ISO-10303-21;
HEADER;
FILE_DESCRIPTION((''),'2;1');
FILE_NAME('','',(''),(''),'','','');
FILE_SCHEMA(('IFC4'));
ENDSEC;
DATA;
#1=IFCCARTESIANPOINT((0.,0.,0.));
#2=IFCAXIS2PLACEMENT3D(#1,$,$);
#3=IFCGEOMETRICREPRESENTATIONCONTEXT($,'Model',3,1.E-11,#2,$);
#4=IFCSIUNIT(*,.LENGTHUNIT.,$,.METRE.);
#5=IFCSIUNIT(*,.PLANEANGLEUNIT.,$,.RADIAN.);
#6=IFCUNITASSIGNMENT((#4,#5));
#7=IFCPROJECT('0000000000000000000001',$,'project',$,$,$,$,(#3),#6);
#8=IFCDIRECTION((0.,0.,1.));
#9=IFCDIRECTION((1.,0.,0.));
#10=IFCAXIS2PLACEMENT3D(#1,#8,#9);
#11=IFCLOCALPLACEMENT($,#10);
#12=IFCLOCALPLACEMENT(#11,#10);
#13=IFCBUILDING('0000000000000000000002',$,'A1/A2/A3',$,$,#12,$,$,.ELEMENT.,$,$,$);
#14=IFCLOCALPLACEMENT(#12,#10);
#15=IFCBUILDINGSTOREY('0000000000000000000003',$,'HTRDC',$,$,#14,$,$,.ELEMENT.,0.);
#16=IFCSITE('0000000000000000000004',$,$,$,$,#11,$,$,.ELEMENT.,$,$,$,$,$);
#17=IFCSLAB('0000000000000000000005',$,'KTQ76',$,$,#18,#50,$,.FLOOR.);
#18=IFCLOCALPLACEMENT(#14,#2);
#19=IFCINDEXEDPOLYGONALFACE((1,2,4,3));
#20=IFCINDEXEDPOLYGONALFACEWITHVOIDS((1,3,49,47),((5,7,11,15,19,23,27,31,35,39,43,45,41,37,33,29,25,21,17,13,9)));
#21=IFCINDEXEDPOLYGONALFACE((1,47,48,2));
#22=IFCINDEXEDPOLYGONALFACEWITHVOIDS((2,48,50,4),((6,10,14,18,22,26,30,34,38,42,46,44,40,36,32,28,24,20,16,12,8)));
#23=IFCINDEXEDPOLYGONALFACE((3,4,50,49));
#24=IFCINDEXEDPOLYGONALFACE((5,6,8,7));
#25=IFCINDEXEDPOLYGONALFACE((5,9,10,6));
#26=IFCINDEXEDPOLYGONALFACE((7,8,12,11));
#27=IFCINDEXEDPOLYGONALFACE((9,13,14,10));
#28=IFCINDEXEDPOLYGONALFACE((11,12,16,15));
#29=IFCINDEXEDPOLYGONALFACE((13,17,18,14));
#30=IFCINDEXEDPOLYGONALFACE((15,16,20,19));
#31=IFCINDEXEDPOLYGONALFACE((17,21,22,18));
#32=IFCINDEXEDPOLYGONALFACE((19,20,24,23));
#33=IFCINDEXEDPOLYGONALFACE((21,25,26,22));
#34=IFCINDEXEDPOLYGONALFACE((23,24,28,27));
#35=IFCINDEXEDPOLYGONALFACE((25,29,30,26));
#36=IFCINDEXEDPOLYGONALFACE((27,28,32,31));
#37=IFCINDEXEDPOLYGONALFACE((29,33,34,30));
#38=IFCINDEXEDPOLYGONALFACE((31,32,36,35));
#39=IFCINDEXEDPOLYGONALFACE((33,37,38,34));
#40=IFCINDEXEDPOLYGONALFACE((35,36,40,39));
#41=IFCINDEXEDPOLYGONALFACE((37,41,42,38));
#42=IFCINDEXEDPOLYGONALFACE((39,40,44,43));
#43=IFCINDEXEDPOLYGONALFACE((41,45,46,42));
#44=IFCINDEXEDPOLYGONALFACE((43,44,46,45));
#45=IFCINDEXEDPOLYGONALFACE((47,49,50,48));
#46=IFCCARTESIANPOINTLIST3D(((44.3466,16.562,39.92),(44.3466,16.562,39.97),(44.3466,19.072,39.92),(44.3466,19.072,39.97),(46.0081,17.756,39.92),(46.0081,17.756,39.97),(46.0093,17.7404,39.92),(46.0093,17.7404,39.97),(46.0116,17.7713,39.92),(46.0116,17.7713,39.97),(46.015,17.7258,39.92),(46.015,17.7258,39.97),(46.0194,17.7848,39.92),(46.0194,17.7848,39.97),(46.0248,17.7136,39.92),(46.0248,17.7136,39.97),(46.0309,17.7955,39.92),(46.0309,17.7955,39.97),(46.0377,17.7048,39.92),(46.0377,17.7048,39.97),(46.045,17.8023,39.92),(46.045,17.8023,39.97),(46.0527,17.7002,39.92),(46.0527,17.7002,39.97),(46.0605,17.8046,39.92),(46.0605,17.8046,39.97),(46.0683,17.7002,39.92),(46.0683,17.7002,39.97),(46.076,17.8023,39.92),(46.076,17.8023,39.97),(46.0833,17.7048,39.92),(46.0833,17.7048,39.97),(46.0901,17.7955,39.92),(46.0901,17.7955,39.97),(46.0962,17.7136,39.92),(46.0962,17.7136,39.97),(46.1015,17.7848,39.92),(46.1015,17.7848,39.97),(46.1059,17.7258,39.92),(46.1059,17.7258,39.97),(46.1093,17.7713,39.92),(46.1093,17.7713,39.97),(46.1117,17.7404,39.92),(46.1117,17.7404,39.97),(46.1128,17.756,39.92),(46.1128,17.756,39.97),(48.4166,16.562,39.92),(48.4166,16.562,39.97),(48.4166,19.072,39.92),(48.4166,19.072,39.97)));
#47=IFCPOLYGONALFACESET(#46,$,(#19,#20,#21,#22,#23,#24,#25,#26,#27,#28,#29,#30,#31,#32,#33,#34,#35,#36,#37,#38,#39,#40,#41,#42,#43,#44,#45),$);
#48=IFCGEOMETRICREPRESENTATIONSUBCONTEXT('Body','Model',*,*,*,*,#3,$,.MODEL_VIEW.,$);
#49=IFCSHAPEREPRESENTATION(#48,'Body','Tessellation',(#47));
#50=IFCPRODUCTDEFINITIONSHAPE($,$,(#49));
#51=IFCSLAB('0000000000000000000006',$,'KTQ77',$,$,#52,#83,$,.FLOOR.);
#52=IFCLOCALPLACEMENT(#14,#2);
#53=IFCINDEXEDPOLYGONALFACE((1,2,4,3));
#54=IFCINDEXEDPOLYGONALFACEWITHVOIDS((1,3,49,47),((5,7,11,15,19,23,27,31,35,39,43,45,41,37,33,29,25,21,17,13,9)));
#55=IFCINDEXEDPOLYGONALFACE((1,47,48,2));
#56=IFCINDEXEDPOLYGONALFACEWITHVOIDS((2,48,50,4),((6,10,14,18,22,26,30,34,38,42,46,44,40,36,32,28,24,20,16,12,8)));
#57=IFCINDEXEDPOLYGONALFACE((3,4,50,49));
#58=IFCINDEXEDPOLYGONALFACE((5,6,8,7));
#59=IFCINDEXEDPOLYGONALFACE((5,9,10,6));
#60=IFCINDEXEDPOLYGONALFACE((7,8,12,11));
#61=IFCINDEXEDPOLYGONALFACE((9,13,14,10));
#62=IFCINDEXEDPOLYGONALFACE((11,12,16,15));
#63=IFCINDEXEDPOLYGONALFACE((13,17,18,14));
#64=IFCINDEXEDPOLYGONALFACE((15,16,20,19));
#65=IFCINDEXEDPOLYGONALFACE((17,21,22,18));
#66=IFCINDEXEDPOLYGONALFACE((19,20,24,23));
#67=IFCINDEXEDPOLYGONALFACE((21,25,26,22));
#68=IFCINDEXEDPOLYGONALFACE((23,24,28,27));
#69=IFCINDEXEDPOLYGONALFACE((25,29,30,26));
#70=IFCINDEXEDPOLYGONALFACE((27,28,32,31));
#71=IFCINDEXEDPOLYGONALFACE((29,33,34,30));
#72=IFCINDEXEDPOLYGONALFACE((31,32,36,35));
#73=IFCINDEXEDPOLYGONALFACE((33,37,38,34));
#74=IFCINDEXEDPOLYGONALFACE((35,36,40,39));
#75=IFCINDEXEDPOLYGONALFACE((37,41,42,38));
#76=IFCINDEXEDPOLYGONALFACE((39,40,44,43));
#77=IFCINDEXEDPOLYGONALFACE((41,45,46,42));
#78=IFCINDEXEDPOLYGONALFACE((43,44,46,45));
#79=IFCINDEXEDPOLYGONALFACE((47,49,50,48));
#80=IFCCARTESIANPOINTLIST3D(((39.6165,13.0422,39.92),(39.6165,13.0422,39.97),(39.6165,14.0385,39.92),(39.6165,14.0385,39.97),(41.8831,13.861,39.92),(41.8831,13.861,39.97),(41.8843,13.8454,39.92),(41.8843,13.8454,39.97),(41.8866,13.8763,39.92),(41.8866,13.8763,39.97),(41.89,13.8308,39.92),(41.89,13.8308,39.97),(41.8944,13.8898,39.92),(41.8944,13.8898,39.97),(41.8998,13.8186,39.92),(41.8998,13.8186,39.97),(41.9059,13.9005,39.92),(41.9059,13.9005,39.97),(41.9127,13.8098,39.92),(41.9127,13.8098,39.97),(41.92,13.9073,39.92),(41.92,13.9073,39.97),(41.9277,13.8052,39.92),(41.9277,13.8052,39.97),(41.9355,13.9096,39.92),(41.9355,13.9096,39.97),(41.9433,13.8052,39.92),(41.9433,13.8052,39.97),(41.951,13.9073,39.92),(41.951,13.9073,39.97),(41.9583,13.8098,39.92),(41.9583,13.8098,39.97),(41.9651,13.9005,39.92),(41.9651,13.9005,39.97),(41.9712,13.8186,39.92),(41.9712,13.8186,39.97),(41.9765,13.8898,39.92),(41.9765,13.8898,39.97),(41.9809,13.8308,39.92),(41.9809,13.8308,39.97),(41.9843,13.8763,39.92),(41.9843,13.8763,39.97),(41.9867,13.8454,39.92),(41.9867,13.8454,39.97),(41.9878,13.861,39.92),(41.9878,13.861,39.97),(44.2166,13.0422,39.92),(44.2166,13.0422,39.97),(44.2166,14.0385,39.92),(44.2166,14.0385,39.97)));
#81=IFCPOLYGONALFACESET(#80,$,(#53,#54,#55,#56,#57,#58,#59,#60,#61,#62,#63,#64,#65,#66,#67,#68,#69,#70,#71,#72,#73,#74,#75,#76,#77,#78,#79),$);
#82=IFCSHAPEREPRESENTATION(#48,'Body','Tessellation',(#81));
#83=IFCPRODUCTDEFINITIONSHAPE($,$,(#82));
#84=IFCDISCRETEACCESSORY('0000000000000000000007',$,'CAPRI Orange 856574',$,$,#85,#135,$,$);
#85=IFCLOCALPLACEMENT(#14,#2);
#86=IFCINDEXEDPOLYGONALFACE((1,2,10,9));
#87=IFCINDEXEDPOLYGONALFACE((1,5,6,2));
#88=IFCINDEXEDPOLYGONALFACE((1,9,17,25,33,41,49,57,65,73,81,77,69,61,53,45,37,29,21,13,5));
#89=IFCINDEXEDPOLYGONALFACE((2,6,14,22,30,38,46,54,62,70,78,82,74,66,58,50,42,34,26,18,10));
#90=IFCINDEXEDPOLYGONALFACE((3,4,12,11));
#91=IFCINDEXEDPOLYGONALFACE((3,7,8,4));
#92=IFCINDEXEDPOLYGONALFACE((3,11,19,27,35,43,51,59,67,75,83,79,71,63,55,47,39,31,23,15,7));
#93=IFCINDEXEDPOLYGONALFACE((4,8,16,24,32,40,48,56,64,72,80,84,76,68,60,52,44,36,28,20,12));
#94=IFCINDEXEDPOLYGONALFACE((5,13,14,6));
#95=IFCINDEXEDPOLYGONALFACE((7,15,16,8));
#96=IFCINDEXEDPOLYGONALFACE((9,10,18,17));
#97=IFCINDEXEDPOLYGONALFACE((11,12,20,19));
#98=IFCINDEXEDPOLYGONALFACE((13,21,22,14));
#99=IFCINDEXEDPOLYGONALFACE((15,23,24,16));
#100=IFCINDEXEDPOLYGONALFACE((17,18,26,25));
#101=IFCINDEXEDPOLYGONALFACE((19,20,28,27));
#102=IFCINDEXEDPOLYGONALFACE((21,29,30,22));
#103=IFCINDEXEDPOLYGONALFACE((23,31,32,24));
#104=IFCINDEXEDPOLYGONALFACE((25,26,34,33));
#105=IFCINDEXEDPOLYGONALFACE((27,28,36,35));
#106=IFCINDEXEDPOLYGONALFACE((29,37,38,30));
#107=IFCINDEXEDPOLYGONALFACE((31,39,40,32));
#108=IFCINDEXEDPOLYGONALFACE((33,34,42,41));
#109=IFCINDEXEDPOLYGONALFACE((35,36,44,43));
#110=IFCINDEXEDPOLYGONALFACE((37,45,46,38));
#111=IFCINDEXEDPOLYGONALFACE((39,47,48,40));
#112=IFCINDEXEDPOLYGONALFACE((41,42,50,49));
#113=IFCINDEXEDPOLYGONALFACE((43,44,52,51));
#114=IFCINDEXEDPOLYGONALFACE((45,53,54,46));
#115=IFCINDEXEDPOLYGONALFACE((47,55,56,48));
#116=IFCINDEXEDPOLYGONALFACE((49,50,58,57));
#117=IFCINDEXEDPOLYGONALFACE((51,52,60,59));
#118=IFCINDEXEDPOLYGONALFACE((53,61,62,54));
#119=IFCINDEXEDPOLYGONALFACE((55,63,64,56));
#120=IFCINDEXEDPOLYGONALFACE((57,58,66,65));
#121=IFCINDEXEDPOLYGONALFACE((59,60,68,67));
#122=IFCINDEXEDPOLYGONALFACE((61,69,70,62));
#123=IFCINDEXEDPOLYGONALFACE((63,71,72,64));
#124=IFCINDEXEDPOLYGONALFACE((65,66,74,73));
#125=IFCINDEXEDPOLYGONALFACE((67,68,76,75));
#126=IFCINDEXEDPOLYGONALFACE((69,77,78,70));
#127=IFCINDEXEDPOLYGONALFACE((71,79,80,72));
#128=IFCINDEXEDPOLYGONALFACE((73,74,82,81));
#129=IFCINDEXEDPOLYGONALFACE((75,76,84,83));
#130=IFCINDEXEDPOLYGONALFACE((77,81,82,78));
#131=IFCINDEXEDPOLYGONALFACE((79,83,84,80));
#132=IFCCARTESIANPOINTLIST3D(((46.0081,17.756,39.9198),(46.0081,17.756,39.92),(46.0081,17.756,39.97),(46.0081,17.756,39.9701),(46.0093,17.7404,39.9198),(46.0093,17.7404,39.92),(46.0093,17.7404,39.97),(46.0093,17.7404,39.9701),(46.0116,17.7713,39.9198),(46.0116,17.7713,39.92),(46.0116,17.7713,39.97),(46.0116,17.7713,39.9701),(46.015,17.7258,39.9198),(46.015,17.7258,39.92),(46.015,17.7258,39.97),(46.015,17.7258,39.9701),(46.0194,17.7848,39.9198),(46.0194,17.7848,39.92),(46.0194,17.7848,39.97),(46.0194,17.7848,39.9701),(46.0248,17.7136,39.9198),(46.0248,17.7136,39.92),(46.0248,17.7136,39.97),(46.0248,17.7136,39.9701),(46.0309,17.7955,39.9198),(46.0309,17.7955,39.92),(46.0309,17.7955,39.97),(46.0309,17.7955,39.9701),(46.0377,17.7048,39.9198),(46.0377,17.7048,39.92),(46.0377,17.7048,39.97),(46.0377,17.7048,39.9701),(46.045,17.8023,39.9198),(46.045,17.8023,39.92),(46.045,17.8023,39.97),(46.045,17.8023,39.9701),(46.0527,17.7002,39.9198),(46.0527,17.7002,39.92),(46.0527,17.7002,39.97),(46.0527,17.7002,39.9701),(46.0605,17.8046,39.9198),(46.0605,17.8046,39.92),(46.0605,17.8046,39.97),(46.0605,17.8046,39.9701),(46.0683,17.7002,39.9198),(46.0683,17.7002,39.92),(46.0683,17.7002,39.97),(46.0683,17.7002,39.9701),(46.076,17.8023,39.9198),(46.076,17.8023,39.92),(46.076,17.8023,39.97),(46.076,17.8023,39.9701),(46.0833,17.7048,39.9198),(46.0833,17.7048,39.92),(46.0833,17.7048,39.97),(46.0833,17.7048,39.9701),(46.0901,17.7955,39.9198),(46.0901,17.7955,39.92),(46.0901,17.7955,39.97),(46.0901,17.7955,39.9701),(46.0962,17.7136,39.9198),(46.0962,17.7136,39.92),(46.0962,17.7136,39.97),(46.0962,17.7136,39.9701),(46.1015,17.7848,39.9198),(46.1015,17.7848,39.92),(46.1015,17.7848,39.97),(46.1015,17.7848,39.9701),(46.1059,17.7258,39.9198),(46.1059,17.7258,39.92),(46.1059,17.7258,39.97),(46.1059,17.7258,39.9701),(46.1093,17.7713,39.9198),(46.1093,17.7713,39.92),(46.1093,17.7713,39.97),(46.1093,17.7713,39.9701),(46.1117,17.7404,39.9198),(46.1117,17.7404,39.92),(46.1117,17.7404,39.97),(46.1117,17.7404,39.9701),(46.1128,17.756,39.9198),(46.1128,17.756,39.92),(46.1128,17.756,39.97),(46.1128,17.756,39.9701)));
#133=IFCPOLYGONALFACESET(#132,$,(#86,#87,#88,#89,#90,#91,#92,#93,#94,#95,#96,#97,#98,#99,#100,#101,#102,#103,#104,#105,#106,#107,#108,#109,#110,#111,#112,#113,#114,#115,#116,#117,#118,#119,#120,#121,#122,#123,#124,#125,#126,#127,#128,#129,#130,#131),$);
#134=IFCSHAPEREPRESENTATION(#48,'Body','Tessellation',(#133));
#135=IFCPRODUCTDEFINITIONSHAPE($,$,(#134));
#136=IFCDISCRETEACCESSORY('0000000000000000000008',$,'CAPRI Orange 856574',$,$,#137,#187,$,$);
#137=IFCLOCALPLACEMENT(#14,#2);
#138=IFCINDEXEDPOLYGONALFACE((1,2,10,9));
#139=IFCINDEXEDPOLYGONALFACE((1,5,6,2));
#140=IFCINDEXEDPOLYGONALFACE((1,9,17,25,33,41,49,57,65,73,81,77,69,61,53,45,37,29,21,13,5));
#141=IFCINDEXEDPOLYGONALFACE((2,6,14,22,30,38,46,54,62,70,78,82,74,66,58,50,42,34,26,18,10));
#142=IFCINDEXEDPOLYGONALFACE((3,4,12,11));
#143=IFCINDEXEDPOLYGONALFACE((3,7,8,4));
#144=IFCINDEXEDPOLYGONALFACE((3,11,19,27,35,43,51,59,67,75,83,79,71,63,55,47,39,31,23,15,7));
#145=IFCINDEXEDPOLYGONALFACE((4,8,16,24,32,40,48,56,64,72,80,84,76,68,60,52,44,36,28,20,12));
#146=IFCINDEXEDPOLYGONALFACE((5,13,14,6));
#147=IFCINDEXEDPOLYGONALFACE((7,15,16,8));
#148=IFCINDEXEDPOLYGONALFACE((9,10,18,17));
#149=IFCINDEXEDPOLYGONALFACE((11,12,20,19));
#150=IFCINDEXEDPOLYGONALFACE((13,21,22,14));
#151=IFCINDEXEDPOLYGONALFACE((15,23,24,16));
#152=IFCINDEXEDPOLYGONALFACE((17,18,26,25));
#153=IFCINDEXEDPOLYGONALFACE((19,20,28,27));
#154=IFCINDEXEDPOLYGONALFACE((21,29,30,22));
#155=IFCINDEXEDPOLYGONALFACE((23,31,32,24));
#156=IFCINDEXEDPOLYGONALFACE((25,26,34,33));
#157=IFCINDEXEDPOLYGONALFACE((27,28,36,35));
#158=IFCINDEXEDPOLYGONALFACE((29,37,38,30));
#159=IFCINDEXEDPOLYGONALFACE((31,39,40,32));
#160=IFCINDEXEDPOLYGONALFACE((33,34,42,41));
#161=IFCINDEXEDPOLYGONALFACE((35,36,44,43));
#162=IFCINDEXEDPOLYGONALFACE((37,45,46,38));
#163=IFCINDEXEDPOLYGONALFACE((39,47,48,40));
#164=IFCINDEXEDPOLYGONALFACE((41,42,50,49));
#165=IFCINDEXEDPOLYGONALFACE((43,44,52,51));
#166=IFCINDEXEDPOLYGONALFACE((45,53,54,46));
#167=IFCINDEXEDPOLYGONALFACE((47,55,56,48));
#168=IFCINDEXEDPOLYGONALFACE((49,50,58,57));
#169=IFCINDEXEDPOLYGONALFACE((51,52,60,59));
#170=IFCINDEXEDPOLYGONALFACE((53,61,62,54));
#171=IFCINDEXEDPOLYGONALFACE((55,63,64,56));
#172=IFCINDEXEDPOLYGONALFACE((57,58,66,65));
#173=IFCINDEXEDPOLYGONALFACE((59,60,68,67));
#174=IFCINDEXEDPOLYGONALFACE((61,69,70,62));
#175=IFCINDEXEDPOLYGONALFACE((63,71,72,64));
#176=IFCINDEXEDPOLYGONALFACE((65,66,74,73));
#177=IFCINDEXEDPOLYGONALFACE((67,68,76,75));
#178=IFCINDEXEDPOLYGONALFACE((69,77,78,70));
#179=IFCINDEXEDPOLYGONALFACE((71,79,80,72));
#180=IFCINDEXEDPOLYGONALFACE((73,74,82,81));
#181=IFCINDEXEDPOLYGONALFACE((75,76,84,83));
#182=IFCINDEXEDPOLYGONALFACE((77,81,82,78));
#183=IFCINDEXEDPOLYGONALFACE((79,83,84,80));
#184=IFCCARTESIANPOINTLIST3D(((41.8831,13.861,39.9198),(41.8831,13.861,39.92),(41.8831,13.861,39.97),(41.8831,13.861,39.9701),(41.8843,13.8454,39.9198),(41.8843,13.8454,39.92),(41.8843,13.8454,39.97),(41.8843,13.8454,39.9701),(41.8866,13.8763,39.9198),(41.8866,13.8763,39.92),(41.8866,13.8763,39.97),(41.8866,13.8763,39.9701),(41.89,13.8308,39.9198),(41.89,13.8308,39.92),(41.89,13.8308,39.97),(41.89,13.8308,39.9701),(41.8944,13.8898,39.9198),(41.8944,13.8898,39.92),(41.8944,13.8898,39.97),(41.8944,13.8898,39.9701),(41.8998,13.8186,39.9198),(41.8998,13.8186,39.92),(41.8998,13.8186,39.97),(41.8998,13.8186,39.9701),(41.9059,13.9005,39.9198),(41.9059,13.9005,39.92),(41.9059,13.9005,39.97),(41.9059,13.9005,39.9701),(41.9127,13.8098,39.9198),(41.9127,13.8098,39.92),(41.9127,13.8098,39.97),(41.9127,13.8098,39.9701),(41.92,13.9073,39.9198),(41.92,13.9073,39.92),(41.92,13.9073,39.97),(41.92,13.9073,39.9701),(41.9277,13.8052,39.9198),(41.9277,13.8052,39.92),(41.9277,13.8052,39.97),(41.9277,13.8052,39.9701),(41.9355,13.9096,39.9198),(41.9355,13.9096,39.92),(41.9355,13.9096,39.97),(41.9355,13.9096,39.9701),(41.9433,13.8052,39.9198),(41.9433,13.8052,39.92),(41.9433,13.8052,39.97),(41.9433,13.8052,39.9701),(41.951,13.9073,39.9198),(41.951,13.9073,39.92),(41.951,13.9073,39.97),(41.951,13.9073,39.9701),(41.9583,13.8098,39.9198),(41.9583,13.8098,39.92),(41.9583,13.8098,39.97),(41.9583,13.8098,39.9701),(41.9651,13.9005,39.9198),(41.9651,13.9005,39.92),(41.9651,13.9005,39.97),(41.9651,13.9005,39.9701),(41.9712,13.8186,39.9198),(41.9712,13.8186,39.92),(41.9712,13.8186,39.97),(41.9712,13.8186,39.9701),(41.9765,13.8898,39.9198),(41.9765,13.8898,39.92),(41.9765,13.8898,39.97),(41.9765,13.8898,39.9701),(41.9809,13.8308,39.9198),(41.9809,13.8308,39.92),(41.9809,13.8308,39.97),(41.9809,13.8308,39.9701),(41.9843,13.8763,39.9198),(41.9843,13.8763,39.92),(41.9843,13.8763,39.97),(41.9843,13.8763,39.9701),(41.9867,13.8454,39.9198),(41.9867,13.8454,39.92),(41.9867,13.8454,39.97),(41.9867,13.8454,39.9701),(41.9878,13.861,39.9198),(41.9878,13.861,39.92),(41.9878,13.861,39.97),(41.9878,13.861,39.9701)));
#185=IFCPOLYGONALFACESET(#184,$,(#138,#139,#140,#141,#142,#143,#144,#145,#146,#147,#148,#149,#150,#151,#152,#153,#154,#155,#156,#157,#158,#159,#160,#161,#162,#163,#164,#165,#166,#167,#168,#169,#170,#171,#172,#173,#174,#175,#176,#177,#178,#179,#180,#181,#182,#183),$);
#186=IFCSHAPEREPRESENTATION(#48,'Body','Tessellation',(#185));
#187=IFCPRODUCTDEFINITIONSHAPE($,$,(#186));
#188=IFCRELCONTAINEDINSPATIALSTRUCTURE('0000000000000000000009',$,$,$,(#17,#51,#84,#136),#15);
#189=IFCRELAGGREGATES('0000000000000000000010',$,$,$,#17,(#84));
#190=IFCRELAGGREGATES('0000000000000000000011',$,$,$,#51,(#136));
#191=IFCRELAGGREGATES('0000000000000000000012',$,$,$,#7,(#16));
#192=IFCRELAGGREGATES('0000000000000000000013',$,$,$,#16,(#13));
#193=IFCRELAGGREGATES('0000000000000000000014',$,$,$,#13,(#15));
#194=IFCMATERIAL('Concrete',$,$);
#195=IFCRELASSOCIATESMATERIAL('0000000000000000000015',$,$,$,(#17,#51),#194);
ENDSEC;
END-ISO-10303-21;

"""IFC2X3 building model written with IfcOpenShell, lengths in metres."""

from ifc_helpers import new_model, si_unit, frame, frame_2d, origin, origin_with_axes, origin_2d_with_axis, place, context, subcontext, project, spatial, polyline, circle, outline, extrude, material, element, aggregate, save


model = new_model("IFC2X3")

# Units and contexts
model_context = context("Model", 3, precision=1e-11, world=origin())
body_context = subcontext(model_context, "Body", "Model", "MODEL_VIEW")
ifc_project = project(units=[si_unit("LENGTHUNIT", "METRE"), si_unit("PLANEANGLEUNIT", "RADIAN")], contexts=[model_context])

# Site, building, storey
site_placement = place(None, origin_with_axes())
site = spatial("IfcSite", under=ifc_project, at=site_placement, CompositionType="ELEMENT")
building_placement = place(site_placement, origin_with_axes())
building = spatial("IfcBuilding", under=site, at=building_placement, Name="A1/A2/A3", CompositionType="ELEMENT")
storey_placement = place(building_placement, origin_with_axes())
storey = spatial("IfcBuildingStorey", under=building, at=storey_placement, Name="HTRDC", CompositionType="ELEMENT", Elevation=0.0)

# Shared definitions
ifc_material = material(Name="Concrete")

# Slabs, openings
slab_1_placement = place(storey_placement, frame((44.3466, 16.562, 39.92), z_axis=(0.0, 0.0, 1.0), x_axis=(1.0, 0.0, 0.0)))
slab_1 = element("IfcSlab", 1, at=slab_1_placement, inside=storey, material=ifc_material, Name="KTQ76", PredefinedType="FLOOR", context=body_context, shape_type="SweptSolid", body=[
    extrude(outline(polyline([(0.0, 0.0), (0.0, -4.07), (2.51, -4.07), (2.51, 0.0), (0.0, 0.0)])), frame((0.0, 0.0, 0.0), z_axis=(0.0, 0.0, 1.0), x_axis=(0.0, 1.0, 0.0)), (0.0, 0.0, 1.0), 0.05),
])
opening_1_placement = place(slab_1_placement, frame((1.7139, 1.1901, 0.0), z_axis=(0.0, 0.0, 1.0), x_axis=(1.0, 0.0, 0.0)))
element("IfcOpeningElement", 2, at=opening_1_placement, cuts=slab_1, ObjectType="Opening", context=body_context, shape_type="SweptSolid", body=[
    extrude(circle(Radius=0.0525, at=origin_2d_with_axis()), frame((0.0, 0.0, 0.0), z_axis=(0.0, 0.0, 1.0), x_axis=(0.0, 1.0, 0.0)), (0.0, 0.0, 1.0), 0.05),
])
slab_2_placement = place(storey_placement, frame((39.6165, 13.0422, 39.92), z_axis=(0.0, 0.0, 1.0), x_axis=(1.0, 0.0, 0.0)))
slab_2 = element("IfcSlab", 3, at=slab_2_placement, inside=storey, material=ifc_material, Name="KTQ77", PredefinedType="FLOOR", context=body_context, shape_type="SweptSolid", body=[
    extrude(outline(polyline([(0.0, 0.0), (0.0, -4.6001), (0.9963, -4.6001), (0.9963, 0.0), (0.0, 0.0)])), frame((0.0, 0.0, 0.0), z_axis=(0.0, 0.0, 1.0), x_axis=(0.0, 1.0, 0.0)), (0.0, 0.0, 1.0), 0.05),
])
opening_2_placement = place(slab_2_placement, frame((2.319, 0.8149, 0.0), z_axis=(0.0, 0.0, 1.0), x_axis=(1.0, 0.0, 0.0)))
element("IfcOpeningElement", 4, at=opening_2_placement, cuts=slab_2, ObjectType="Opening", context=body_context, shape_type="SweptSolid", body=[
    extrude(circle(Radius=0.0525, at=origin_2d_with_axis()), frame((0.0, 0.0, 0.0), z_axis=(0.0, 0.0, 1.0), x_axis=(0.0, 1.0, 0.0)), (0.0, 0.0, 1.0), 0.05),
])

# Discrete accessories
discrete_accessory_1_placement = place(storey_placement, frame((44.3466, 16.562, 39.9198), z_axis=(0.0, 0.0, 1.0), x_axis=(1.0, 0.0, 0.0)))
discrete_accessory_1 = element("IfcDiscreteAccessory", 5, at=discrete_accessory_1_placement, inside=storey, Name="CAPRI Orange 856574", context=body_context, shape_type="SweptSolid", body=[
    extrude(circle(Radius=0.0525, at=frame_2d((1.1901, -1.7139), x_axis=(1.0, 0.0))), frame((0.0, 0.0, 0.0), z_axis=(0.0, 0.0, 1.0), x_axis=(0.0, 1.0, 0.0)), (0.0, 0.0, 1.0), 0.0503),
])
aggregate(slab_1, [discrete_accessory_1])
discrete_accessory_2_placement = place(storey_placement, frame((39.6165, 13.0422, 39.9198), z_axis=(0.0, 0.0, 1.0), x_axis=(1.0, 0.0, 0.0)))
discrete_accessory_2 = element("IfcDiscreteAccessory", 6, at=discrete_accessory_2_placement, inside=storey, Name="CAPRI Orange 856574", context=body_context, shape_type="SweptSolid", body=[
    extrude(circle(Radius=0.0525, at=frame_2d((0.8149, -2.319), x_axis=(1.0, 0.0))), frame((0.0, 0.0, 0.0), z_axis=(0.0, 0.0, 1.0), x_axis=(0.0, 1.0, 0.0)), (0.0, 0.0, 1.0), 0.0503),
])
aggregate(slab_2, [discrete_accessory_2])

save(model, "model.ifc")
